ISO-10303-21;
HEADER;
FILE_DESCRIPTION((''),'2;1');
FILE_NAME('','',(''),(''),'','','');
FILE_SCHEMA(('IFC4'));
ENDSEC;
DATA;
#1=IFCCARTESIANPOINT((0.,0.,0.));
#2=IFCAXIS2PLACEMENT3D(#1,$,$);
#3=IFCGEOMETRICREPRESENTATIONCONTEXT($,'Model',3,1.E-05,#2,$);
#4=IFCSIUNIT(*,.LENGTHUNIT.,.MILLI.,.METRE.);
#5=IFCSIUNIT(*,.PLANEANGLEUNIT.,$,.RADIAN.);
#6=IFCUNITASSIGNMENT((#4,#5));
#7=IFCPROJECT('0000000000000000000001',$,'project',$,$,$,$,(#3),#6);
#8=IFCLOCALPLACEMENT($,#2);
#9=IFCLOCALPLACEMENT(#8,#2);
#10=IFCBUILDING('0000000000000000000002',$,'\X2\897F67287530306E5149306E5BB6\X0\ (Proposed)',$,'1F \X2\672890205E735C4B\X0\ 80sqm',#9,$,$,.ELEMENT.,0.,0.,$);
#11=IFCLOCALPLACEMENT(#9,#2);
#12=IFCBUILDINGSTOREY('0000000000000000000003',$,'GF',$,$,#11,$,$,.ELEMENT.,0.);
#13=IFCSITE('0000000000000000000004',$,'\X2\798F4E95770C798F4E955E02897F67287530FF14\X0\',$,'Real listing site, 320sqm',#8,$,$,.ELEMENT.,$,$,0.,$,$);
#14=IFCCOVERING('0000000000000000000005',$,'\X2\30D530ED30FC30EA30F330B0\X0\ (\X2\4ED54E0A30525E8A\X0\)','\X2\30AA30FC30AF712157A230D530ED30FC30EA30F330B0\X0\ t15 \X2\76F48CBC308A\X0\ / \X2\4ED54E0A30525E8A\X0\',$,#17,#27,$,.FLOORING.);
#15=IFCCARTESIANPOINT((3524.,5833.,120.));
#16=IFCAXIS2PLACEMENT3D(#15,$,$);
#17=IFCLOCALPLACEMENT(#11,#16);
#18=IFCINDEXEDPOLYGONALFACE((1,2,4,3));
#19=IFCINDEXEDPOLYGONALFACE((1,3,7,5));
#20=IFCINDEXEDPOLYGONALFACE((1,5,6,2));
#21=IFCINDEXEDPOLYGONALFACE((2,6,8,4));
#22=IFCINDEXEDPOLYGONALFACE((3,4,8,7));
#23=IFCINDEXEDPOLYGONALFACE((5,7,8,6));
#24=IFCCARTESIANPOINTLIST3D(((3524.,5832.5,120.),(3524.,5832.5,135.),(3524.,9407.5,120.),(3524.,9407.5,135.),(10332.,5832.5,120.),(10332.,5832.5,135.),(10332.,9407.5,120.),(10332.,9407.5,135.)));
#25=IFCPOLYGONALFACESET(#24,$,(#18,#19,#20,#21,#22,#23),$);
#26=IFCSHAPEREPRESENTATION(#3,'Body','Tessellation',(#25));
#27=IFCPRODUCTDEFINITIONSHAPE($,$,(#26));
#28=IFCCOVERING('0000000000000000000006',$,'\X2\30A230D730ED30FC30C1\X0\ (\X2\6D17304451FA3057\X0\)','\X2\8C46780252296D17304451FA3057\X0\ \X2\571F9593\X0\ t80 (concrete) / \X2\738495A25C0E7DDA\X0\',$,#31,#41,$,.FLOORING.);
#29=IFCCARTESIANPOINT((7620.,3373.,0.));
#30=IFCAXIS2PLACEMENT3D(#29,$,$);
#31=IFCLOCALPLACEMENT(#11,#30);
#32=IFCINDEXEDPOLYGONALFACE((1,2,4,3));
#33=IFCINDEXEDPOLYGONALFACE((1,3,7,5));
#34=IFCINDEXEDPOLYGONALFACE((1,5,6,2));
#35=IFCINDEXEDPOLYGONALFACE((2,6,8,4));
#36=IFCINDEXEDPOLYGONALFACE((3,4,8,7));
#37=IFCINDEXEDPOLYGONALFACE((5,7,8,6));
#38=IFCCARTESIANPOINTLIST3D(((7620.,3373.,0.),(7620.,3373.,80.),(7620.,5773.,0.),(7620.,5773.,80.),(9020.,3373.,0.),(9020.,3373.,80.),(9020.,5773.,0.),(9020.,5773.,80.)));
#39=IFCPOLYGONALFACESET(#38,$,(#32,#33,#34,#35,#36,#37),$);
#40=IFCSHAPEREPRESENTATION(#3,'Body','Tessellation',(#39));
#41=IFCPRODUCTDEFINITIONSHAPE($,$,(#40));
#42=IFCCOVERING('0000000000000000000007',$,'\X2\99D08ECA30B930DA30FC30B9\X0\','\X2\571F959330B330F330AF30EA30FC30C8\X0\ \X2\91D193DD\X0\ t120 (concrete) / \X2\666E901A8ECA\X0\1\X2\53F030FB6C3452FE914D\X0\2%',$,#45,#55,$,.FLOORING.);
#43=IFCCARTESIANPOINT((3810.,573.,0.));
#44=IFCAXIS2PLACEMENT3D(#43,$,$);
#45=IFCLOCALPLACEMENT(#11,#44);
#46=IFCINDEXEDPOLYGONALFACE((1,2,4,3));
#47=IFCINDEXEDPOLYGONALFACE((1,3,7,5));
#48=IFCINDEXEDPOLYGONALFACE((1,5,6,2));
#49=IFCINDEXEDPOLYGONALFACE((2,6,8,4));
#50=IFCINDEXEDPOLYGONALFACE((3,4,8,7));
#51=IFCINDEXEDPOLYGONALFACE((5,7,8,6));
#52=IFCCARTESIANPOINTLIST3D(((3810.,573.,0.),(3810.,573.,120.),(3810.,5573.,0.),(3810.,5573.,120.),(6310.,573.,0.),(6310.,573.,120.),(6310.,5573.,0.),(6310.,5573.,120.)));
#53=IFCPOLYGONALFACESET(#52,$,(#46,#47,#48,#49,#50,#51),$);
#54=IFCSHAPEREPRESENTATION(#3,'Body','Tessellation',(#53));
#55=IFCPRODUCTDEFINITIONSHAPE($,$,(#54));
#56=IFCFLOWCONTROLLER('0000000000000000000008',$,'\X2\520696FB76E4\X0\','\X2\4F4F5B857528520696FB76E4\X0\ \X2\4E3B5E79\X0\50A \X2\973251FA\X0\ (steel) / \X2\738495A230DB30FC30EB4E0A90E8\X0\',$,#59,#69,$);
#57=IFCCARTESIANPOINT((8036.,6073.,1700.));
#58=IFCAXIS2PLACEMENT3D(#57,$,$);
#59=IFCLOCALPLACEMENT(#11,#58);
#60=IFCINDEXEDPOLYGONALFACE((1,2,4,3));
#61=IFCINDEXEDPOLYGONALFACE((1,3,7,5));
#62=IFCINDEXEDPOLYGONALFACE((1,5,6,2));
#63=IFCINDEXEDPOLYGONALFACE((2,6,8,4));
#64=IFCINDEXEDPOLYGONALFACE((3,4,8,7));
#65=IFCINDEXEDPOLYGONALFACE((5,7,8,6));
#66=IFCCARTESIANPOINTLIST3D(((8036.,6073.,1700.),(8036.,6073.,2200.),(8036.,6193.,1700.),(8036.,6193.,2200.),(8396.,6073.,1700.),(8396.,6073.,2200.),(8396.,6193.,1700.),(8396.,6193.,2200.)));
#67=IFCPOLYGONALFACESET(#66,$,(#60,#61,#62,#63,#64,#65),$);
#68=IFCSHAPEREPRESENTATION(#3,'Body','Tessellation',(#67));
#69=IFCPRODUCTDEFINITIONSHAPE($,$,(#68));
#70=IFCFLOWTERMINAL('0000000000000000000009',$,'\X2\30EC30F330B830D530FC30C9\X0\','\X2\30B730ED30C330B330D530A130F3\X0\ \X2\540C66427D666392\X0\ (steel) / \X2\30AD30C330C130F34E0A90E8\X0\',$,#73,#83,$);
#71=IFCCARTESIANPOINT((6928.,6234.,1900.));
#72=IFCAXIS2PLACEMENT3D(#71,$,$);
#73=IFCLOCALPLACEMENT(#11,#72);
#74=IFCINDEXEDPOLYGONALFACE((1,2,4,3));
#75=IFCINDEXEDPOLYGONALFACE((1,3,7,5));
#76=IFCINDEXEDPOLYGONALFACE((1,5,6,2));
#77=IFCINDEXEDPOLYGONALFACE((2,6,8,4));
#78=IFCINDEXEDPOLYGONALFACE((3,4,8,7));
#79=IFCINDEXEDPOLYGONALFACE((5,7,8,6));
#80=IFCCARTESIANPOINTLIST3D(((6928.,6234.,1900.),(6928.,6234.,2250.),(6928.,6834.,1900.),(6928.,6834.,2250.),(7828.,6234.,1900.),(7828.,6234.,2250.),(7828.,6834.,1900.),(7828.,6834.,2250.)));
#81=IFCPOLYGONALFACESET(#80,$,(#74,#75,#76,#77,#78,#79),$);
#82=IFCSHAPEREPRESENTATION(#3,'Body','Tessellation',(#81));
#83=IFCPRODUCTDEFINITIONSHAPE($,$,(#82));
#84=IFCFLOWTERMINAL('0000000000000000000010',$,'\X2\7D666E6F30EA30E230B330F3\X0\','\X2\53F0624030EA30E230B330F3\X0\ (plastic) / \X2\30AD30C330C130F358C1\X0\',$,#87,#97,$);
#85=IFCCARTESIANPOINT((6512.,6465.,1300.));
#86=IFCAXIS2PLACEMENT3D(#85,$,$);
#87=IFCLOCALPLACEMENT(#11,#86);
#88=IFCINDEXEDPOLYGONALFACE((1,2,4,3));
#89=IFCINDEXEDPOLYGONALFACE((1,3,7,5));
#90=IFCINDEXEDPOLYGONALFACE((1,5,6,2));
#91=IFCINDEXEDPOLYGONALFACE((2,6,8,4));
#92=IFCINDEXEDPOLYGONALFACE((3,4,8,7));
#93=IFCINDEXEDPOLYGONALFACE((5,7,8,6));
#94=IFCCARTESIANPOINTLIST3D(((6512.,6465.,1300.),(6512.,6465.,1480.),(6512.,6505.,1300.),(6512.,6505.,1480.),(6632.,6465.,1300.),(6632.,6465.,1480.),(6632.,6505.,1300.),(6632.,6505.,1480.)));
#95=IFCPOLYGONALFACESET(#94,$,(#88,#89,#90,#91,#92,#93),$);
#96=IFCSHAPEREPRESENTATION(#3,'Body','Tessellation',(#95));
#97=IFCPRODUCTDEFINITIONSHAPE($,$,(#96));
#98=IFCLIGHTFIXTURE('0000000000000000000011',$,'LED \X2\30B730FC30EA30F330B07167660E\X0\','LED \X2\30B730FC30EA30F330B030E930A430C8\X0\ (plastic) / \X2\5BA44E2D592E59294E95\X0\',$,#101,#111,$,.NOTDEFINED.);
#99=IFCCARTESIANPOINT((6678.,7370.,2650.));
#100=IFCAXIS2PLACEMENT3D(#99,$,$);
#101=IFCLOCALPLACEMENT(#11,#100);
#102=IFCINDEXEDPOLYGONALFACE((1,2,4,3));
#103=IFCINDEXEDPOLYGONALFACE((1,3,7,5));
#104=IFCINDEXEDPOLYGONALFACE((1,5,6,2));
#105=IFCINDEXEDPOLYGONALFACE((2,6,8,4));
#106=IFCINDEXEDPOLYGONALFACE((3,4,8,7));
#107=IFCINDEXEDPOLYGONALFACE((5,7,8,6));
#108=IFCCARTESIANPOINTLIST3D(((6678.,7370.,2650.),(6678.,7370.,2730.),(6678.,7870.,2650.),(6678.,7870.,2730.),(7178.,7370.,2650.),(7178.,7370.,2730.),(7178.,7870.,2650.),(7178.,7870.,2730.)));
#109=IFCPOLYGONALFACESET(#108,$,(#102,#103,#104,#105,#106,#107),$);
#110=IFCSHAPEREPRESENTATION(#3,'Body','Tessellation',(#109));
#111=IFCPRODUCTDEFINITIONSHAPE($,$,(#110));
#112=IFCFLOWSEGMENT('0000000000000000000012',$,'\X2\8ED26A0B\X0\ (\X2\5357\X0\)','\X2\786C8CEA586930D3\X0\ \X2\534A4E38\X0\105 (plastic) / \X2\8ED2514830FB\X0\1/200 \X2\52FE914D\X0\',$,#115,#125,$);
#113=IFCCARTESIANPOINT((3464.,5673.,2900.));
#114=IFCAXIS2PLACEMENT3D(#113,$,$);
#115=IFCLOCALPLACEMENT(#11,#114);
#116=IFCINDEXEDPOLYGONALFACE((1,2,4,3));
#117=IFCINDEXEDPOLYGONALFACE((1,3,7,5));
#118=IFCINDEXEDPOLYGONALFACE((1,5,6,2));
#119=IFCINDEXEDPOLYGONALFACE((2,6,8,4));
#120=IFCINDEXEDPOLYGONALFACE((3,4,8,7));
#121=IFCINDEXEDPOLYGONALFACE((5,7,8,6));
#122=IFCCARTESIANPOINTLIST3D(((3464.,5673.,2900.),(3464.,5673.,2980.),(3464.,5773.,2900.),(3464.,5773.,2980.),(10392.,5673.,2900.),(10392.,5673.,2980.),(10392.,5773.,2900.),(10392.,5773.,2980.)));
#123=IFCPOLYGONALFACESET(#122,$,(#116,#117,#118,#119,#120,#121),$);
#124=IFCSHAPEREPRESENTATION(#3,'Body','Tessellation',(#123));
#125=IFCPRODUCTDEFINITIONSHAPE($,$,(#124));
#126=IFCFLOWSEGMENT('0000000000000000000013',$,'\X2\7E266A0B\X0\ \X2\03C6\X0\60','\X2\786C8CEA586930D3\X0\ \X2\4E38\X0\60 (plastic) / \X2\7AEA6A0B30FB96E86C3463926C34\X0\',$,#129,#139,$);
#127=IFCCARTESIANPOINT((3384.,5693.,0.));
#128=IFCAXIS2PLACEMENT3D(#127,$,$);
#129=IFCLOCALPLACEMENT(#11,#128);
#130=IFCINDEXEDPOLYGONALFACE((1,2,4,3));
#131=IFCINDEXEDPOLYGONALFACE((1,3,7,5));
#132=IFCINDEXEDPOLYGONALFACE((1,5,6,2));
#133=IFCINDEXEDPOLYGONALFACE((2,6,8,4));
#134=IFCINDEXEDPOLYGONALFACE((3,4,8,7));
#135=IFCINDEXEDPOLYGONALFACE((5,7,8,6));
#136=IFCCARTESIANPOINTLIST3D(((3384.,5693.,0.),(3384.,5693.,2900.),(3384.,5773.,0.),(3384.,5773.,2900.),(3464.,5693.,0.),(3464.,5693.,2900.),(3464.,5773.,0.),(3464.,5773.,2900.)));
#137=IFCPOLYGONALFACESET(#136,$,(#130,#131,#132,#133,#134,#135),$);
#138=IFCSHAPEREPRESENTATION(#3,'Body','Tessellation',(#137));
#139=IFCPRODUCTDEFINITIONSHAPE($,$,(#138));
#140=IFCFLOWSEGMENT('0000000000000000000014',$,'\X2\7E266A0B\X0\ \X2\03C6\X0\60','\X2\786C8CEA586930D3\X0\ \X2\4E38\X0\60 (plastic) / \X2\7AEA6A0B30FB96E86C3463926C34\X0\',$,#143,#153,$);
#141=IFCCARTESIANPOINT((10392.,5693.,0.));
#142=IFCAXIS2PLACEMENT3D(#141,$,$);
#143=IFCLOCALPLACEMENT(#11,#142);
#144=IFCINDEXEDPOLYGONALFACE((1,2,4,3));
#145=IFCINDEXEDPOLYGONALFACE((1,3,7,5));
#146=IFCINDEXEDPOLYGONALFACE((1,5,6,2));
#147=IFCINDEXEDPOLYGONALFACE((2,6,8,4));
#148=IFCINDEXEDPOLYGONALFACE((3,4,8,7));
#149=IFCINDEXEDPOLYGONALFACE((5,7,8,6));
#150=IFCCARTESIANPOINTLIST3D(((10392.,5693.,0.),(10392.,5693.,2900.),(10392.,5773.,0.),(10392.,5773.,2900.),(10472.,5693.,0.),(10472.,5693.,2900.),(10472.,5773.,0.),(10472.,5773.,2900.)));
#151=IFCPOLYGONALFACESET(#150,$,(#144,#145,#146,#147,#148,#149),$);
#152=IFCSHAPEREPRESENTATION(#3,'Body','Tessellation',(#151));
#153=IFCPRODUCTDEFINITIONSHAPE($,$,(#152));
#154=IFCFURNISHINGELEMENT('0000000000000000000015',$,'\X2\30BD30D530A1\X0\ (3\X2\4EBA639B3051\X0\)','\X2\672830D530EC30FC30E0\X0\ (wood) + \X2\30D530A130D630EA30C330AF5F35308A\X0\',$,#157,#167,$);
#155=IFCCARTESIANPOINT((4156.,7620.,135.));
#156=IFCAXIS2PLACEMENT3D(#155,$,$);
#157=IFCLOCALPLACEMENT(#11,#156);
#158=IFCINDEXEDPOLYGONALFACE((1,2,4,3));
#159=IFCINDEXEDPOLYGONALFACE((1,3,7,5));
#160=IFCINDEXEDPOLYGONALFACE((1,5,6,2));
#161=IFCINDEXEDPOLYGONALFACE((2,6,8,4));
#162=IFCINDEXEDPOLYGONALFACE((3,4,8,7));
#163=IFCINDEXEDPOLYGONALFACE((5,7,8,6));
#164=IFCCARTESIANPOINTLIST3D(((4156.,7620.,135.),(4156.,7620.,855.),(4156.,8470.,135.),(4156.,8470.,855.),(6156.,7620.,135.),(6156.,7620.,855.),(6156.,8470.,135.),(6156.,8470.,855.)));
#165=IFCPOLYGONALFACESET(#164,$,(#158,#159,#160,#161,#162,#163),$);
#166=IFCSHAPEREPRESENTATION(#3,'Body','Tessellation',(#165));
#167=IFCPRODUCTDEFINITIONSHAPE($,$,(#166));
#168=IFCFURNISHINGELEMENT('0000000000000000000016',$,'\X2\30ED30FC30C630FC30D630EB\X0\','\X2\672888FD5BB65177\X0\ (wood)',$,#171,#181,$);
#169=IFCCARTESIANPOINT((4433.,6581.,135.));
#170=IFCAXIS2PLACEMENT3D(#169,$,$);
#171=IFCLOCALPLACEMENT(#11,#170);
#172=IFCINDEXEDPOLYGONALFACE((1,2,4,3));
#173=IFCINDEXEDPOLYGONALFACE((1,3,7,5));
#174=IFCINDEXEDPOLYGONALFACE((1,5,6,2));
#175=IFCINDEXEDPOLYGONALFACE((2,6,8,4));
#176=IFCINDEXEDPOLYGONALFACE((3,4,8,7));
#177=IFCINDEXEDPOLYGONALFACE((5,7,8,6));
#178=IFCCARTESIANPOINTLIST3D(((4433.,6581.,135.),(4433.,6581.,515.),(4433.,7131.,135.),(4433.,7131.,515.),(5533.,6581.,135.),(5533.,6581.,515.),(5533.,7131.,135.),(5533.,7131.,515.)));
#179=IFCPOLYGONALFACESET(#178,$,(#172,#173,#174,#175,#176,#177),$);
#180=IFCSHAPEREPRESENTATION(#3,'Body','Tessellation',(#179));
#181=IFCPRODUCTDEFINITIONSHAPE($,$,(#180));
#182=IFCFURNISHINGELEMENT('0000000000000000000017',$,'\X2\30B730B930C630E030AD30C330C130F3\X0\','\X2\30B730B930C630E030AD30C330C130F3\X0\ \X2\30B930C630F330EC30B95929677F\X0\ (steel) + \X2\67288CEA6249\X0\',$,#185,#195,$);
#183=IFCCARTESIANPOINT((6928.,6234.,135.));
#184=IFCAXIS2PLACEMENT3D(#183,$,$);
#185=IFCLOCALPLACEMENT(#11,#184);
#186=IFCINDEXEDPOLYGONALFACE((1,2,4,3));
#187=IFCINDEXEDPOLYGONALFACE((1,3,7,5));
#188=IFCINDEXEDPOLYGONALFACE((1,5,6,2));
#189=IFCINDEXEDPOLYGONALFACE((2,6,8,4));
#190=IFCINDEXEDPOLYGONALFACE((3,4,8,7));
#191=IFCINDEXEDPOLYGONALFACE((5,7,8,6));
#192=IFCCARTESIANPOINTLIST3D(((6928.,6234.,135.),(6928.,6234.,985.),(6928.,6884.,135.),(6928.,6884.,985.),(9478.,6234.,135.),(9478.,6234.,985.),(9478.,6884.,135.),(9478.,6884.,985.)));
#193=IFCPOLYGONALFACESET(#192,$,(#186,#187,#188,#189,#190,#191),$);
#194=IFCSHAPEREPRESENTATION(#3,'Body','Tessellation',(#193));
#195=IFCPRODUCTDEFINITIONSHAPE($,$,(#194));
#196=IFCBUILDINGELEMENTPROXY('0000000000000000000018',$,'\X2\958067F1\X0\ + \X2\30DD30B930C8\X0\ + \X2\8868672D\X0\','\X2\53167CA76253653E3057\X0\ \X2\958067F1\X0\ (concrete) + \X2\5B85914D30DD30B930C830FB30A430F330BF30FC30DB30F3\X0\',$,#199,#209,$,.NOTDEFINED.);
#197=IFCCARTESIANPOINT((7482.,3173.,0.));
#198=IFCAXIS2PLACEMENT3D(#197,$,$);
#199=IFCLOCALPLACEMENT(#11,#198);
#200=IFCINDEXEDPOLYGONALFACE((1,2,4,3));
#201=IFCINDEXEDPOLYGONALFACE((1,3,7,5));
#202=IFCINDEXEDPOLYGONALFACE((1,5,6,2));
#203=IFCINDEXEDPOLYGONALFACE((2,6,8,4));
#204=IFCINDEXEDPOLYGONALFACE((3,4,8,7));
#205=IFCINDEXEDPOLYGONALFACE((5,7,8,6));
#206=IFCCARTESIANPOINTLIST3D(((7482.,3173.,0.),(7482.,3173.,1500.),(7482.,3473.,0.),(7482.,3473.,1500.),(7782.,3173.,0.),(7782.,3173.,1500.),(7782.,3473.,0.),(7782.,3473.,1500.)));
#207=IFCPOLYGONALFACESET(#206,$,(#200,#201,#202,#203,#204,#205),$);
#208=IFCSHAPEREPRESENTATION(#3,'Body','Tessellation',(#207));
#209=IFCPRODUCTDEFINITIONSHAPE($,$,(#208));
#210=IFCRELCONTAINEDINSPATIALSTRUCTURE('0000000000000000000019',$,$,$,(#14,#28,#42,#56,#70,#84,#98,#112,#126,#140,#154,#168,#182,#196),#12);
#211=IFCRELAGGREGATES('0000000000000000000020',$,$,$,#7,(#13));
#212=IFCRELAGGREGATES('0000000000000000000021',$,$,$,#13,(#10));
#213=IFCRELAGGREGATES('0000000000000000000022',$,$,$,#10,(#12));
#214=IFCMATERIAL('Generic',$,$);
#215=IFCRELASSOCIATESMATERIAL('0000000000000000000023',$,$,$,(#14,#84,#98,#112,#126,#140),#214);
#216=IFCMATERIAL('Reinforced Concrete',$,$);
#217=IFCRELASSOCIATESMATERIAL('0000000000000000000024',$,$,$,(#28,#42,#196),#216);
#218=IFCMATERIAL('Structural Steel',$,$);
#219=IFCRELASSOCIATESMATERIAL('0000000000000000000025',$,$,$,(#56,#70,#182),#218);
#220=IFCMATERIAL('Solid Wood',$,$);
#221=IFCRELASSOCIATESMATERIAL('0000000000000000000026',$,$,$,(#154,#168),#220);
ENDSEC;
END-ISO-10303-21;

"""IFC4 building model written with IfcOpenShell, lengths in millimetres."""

from ifc_helpers import new_model, si_unit, frame, frame_2d, origin, place, context, project, spatial, rectangle, extrude, material, element, save


model = new_model("IFC4")

# Units and contexts
model_context = context("Model", 3, precision=1e-05, world=origin())
ifc_project = project(units=[si_unit("LENGTHUNIT", "METRE", prefix="MILLI"), si_unit("PLANEANGLEUNIT", "RADIAN")], contexts=[model_context])

# Site, building, storey
site_placement = place(None, origin())
site = spatial("IfcSite", under=ifc_project, at=site_placement, Name="福井県福井市西木田４", ObjectType="Real listing site, 320sqm", CompositionType="ELEMENT", RefElevation=0.0)
building_placement = place(site_placement, origin())
building = spatial("IfcBuilding", under=site, at=building_placement, Name="西木田の光の家 (Proposed)", ObjectType="1F 木造平屋 80sqm", CompositionType="ELEMENT", ElevationOfRefHeight=0.0, ElevationOfTerrain=0.0)
storey_placement = place(building_placement, origin())
storey = spatial("IfcBuildingStorey", under=building, at=storey_placement, Name="GF", CompositionType="ELEMENT", Elevation=0.0)

# Shared definitions
ifc_material_1 = material(Name="Solid Wood")

# Shared definitions
ifc_material_2 = material(Name="Reinforced Concrete")

# Shared definitions
ifc_material_3 = material(Name="Structural Steel")

# Coverings
ifc_material_4 = material(Name="Generic")
covering_1_placement = place(storey_placement, frame((3524.0, 5833.0, 120.0)))
element("IfcCovering", 1, at=covering_1_placement, inside=storey, material=ifc_material_4, Name="フローリング (仕上げ床)", Description="オーク無垢フローリング t15 直貼り / 仕上げ床", PredefinedType="FLOORING", context=model_context, shape_type="SweptSolid", body=[
    extrude(rectangle(XDim=6808.0, YDim=3575.0, at=frame_2d((3404.0, 1787.0))), frame((3524.0, 5833.0, 120.0)), (0.0, 0.0, 1.0), 15.0),
])
covering_2_placement = place(storey_placement, frame((7620.0, 3373.0, 0.0)))
element("IfcCovering", 2, at=covering_2_placement, inside=storey, material=ifc_material_2, Name="アプローチ (洗い出し)", Description="豆砂利洗い出し 土間 t80 (concrete) / 玄関導線", PredefinedType="FLOORING", context=model_context, shape_type="SweptSolid", body=[
    extrude(rectangle(XDim=1400.0, YDim=2400.0, at=frame_2d((700.0, 1200.0))), frame((7620.0, 3373.0, 0.0)), (0.0, 0.0, 1.0), 80.0),
])
covering_3_placement = place(storey_placement, frame((3810.0, 573.0, 0.0)))
element("IfcCovering", 3, at=covering_3_placement, inside=storey, material=ifc_material_2, Name="駐車スペース", Description="土間コンクリート 金鏝 t120 (concrete) / 普通車1台・水勾配2%", PredefinedType="FLOORING", context=model_context, shape_type="SweptSolid", body=[
    extrude(rectangle(XDim=2500.0, YDim=5000.0, at=frame_2d((1250.0, 2500.0))), frame((3810.0, 573.0, 0.0)), (0.0, 0.0, 1.0), 120.0),
])

# Flow controller
flow_controller_placement = place(storey_placement, frame((8036.0, 6073.0, 1700.0)))
element("IfcFlowController", 4, at=flow_controller_placement, inside=storey, material=ifc_material_3, Name="分電盤", Description="住宅用分電盤 主幹50A 露出 (steel) / 玄関ホール上部", context=model_context, shape_type="SweptSolid", body=[
    extrude(rectangle(XDim=360.0, YDim=120.0, at=frame_2d((180.0, 60.0))), frame((8036.0, 6073.0, 1700.0)), (0.0, 0.0, 1.0), 500.0),
])

# Flow terminals
flow_terminal_1_placement = place(storey_placement, frame((6928.0, 6234.0, 1900.0)))
element("IfcFlowTerminal", 5, at=flow_terminal_1_placement, inside=storey, material=ifc_material_3, Name="レンジフード", Description="シロッコファン 同時給排 (steel) / キッチン上部", context=model_context, shape_type="SweptSolid", body=[
    extrude(rectangle(XDim=900.0, YDim=600.0, at=frame_2d((450.0, 300.0))), frame((6928.0, 6234.0, 1900.0)), (0.0, 0.0, 1.0), 350.0),
])
flow_terminal_2_placement = place(storey_placement, frame((6512.0, 6465.0, 1300.0)))
element("IfcFlowTerminal", 6, at=flow_terminal_2_placement, inside=storey, material=ifc_material_4, Name="給湯リモコン", Description="台所リモコン (plastic) / キッチン壁", context=model_context, shape_type="SweptSolid", body=[
    extrude(rectangle(XDim=120.0, YDim=40.0, at=frame_2d((60.0, 20.0))), frame((6512.0, 6465.0, 1300.0)), (0.0, 0.0, 1.0), 180.0),
])

# Light fixture
light_fixture_placement = place(storey_placement, frame((6678.0, 7370.0, 2650.0)))
element("IfcLightFixture", 7, at=light_fixture_placement, inside=storey, material=ifc_material_4, Name="LED シーリング照明", Description="LED シーリングライト (plastic) / 室中央天井", PredefinedType="NOTDEFINED", context=model_context, shape_type="SweptSolid", body=[
    extrude(rectangle(XDim=500.0, YDim=500.0, at=frame_2d((250.0, 250.0))), frame((6678.0, 7370.0, 2650.0)), (0.0, 0.0, 1.0), 80.0),
])

# Flow segments
flow_segment_1_placement = place(storey_placement, frame((3464.0, 5673.0, 2900.0)))
element("IfcFlowSegment", 8, at=flow_segment_1_placement, inside=storey, material=ifc_material_4, Name="軒樋 (南)", Description="硬質塩ビ 半丸105 (plastic) / 軒先・1/200 勾配", context=model_context, shape_type="SweptSolid", body=[
    extrude(rectangle(XDim=6928.0, YDim=100.0, at=frame_2d((3464.0, 50.0))), frame((3464.0, 5673.0, 2900.0)), (0.0, 0.0, 1.0), 80.0),
])
flow_segment_2_placement = place(storey_placement, frame((3384.0, 5693.0, 0.0)))
element("IfcFlowSegment", 9, at=flow_segment_2_placement, inside=storey, material=ifc_material_4, Name="縦樋 φ60", Description="硬質塩ビ 丸60 (plastic) / 竪樋・雨水排水", context=model_context, shape_type="SweptSolid", body=[
    extrude(rectangle(XDim=80.0, YDim=80.0, at=frame_2d((40.0, 40.0))), frame((3384.0, 5693.0, 0.0)), (0.0, 0.0, 1.0), 2900.0),
])
flow_segment_3_placement = place(storey_placement, frame((10392.0, 5693.0, 0.0)))
element("IfcFlowSegment", 10, at=flow_segment_3_placement, inside=storey, material=ifc_material_4, Name="縦樋 φ60", Description="硬質塩ビ 丸60 (plastic) / 竪樋・雨水排水", context=model_context, shape_type="SweptSolid", body=[
    extrude(rectangle(XDim=80.0, YDim=80.0, at=frame_2d((40.0, 40.0))), frame((10392.0, 5693.0, 0.0)), (0.0, 0.0, 1.0), 2900.0),
])

# Furnishing elements
furnishing_1_placement = place(storey_placement, frame((4156.0, 7620.0, 135.0)))
element("IfcFurnishingElement", 11, at=furnishing_1_placement, inside=storey, material=ifc_material_1, Name="ソファ (3人掛け)", Description="木フレーム (wood) + ファブリック張り", context=model_context, shape_type="SweptSolid", body=[
    extrude(rectangle(XDim=2000.0, YDim=850.0, at=frame_2d((1000.0, 425.0))), frame((4156.0, 7620.0, 135.0)), (0.0, 0.0, 1.0), 720.0),
])
furnishing_2_placement = place(storey_placement, frame((4433.0, 6581.0, 135.0)))
element("IfcFurnishingElement", 12, at=furnishing_2_placement, inside=storey, material=ifc_material_1, Name="ローテーブル", Description="木製家具 (wood)", context=model_context, shape_type="SweptSolid", body=[
    extrude(rectangle(XDim=1100.0, YDim=550.0, at=frame_2d((550.0, 275.0))), frame((4433.0, 6581.0, 135.0)), (0.0, 0.0, 1.0), 380.0),
])
furnishing_3_placement = place(storey_placement, frame((6928.0, 6234.0, 135.0)))
element("IfcFurnishingElement", 13, at=furnishing_3_placement, inside=storey, material=ifc_material_3, Name="システムキッチン", Description="システムキッチン ステンレス天板 (steel) + 木質扉", context=model_context, shape_type="SweptSolid", body=[
    extrude(rectangle(XDim=2550.0, YDim=650.0, at=frame_2d((1275.0, 325.0))), frame((6928.0, 6234.0, 135.0)), (0.0, 0.0, 1.0), 850.0),
])

# Building element proxy
proxy_placement = place(storey_placement, frame((7482.0, 3173.0, 0.0)))
element("IfcBuildingElementProxy", 14, at=proxy_placement, inside=storey, material=ifc_material_2, Name="門柱 + ポスト + 表札", Description="化粧打放し 門柱 (concrete) + 宅配ポスト・インターホン", PredefinedType="NOTDEFINED", context=model_context, shape_type="SweptSolid", body=[
    extrude(rectangle(XDim=300.0, YDim=300.0, at=frame_2d((150.0, 150.0))), frame((7482.0, 3173.0, 0.0)), (0.0, 0.0, 1.0), 1500.0),
])

save(model, "model.ifc")
